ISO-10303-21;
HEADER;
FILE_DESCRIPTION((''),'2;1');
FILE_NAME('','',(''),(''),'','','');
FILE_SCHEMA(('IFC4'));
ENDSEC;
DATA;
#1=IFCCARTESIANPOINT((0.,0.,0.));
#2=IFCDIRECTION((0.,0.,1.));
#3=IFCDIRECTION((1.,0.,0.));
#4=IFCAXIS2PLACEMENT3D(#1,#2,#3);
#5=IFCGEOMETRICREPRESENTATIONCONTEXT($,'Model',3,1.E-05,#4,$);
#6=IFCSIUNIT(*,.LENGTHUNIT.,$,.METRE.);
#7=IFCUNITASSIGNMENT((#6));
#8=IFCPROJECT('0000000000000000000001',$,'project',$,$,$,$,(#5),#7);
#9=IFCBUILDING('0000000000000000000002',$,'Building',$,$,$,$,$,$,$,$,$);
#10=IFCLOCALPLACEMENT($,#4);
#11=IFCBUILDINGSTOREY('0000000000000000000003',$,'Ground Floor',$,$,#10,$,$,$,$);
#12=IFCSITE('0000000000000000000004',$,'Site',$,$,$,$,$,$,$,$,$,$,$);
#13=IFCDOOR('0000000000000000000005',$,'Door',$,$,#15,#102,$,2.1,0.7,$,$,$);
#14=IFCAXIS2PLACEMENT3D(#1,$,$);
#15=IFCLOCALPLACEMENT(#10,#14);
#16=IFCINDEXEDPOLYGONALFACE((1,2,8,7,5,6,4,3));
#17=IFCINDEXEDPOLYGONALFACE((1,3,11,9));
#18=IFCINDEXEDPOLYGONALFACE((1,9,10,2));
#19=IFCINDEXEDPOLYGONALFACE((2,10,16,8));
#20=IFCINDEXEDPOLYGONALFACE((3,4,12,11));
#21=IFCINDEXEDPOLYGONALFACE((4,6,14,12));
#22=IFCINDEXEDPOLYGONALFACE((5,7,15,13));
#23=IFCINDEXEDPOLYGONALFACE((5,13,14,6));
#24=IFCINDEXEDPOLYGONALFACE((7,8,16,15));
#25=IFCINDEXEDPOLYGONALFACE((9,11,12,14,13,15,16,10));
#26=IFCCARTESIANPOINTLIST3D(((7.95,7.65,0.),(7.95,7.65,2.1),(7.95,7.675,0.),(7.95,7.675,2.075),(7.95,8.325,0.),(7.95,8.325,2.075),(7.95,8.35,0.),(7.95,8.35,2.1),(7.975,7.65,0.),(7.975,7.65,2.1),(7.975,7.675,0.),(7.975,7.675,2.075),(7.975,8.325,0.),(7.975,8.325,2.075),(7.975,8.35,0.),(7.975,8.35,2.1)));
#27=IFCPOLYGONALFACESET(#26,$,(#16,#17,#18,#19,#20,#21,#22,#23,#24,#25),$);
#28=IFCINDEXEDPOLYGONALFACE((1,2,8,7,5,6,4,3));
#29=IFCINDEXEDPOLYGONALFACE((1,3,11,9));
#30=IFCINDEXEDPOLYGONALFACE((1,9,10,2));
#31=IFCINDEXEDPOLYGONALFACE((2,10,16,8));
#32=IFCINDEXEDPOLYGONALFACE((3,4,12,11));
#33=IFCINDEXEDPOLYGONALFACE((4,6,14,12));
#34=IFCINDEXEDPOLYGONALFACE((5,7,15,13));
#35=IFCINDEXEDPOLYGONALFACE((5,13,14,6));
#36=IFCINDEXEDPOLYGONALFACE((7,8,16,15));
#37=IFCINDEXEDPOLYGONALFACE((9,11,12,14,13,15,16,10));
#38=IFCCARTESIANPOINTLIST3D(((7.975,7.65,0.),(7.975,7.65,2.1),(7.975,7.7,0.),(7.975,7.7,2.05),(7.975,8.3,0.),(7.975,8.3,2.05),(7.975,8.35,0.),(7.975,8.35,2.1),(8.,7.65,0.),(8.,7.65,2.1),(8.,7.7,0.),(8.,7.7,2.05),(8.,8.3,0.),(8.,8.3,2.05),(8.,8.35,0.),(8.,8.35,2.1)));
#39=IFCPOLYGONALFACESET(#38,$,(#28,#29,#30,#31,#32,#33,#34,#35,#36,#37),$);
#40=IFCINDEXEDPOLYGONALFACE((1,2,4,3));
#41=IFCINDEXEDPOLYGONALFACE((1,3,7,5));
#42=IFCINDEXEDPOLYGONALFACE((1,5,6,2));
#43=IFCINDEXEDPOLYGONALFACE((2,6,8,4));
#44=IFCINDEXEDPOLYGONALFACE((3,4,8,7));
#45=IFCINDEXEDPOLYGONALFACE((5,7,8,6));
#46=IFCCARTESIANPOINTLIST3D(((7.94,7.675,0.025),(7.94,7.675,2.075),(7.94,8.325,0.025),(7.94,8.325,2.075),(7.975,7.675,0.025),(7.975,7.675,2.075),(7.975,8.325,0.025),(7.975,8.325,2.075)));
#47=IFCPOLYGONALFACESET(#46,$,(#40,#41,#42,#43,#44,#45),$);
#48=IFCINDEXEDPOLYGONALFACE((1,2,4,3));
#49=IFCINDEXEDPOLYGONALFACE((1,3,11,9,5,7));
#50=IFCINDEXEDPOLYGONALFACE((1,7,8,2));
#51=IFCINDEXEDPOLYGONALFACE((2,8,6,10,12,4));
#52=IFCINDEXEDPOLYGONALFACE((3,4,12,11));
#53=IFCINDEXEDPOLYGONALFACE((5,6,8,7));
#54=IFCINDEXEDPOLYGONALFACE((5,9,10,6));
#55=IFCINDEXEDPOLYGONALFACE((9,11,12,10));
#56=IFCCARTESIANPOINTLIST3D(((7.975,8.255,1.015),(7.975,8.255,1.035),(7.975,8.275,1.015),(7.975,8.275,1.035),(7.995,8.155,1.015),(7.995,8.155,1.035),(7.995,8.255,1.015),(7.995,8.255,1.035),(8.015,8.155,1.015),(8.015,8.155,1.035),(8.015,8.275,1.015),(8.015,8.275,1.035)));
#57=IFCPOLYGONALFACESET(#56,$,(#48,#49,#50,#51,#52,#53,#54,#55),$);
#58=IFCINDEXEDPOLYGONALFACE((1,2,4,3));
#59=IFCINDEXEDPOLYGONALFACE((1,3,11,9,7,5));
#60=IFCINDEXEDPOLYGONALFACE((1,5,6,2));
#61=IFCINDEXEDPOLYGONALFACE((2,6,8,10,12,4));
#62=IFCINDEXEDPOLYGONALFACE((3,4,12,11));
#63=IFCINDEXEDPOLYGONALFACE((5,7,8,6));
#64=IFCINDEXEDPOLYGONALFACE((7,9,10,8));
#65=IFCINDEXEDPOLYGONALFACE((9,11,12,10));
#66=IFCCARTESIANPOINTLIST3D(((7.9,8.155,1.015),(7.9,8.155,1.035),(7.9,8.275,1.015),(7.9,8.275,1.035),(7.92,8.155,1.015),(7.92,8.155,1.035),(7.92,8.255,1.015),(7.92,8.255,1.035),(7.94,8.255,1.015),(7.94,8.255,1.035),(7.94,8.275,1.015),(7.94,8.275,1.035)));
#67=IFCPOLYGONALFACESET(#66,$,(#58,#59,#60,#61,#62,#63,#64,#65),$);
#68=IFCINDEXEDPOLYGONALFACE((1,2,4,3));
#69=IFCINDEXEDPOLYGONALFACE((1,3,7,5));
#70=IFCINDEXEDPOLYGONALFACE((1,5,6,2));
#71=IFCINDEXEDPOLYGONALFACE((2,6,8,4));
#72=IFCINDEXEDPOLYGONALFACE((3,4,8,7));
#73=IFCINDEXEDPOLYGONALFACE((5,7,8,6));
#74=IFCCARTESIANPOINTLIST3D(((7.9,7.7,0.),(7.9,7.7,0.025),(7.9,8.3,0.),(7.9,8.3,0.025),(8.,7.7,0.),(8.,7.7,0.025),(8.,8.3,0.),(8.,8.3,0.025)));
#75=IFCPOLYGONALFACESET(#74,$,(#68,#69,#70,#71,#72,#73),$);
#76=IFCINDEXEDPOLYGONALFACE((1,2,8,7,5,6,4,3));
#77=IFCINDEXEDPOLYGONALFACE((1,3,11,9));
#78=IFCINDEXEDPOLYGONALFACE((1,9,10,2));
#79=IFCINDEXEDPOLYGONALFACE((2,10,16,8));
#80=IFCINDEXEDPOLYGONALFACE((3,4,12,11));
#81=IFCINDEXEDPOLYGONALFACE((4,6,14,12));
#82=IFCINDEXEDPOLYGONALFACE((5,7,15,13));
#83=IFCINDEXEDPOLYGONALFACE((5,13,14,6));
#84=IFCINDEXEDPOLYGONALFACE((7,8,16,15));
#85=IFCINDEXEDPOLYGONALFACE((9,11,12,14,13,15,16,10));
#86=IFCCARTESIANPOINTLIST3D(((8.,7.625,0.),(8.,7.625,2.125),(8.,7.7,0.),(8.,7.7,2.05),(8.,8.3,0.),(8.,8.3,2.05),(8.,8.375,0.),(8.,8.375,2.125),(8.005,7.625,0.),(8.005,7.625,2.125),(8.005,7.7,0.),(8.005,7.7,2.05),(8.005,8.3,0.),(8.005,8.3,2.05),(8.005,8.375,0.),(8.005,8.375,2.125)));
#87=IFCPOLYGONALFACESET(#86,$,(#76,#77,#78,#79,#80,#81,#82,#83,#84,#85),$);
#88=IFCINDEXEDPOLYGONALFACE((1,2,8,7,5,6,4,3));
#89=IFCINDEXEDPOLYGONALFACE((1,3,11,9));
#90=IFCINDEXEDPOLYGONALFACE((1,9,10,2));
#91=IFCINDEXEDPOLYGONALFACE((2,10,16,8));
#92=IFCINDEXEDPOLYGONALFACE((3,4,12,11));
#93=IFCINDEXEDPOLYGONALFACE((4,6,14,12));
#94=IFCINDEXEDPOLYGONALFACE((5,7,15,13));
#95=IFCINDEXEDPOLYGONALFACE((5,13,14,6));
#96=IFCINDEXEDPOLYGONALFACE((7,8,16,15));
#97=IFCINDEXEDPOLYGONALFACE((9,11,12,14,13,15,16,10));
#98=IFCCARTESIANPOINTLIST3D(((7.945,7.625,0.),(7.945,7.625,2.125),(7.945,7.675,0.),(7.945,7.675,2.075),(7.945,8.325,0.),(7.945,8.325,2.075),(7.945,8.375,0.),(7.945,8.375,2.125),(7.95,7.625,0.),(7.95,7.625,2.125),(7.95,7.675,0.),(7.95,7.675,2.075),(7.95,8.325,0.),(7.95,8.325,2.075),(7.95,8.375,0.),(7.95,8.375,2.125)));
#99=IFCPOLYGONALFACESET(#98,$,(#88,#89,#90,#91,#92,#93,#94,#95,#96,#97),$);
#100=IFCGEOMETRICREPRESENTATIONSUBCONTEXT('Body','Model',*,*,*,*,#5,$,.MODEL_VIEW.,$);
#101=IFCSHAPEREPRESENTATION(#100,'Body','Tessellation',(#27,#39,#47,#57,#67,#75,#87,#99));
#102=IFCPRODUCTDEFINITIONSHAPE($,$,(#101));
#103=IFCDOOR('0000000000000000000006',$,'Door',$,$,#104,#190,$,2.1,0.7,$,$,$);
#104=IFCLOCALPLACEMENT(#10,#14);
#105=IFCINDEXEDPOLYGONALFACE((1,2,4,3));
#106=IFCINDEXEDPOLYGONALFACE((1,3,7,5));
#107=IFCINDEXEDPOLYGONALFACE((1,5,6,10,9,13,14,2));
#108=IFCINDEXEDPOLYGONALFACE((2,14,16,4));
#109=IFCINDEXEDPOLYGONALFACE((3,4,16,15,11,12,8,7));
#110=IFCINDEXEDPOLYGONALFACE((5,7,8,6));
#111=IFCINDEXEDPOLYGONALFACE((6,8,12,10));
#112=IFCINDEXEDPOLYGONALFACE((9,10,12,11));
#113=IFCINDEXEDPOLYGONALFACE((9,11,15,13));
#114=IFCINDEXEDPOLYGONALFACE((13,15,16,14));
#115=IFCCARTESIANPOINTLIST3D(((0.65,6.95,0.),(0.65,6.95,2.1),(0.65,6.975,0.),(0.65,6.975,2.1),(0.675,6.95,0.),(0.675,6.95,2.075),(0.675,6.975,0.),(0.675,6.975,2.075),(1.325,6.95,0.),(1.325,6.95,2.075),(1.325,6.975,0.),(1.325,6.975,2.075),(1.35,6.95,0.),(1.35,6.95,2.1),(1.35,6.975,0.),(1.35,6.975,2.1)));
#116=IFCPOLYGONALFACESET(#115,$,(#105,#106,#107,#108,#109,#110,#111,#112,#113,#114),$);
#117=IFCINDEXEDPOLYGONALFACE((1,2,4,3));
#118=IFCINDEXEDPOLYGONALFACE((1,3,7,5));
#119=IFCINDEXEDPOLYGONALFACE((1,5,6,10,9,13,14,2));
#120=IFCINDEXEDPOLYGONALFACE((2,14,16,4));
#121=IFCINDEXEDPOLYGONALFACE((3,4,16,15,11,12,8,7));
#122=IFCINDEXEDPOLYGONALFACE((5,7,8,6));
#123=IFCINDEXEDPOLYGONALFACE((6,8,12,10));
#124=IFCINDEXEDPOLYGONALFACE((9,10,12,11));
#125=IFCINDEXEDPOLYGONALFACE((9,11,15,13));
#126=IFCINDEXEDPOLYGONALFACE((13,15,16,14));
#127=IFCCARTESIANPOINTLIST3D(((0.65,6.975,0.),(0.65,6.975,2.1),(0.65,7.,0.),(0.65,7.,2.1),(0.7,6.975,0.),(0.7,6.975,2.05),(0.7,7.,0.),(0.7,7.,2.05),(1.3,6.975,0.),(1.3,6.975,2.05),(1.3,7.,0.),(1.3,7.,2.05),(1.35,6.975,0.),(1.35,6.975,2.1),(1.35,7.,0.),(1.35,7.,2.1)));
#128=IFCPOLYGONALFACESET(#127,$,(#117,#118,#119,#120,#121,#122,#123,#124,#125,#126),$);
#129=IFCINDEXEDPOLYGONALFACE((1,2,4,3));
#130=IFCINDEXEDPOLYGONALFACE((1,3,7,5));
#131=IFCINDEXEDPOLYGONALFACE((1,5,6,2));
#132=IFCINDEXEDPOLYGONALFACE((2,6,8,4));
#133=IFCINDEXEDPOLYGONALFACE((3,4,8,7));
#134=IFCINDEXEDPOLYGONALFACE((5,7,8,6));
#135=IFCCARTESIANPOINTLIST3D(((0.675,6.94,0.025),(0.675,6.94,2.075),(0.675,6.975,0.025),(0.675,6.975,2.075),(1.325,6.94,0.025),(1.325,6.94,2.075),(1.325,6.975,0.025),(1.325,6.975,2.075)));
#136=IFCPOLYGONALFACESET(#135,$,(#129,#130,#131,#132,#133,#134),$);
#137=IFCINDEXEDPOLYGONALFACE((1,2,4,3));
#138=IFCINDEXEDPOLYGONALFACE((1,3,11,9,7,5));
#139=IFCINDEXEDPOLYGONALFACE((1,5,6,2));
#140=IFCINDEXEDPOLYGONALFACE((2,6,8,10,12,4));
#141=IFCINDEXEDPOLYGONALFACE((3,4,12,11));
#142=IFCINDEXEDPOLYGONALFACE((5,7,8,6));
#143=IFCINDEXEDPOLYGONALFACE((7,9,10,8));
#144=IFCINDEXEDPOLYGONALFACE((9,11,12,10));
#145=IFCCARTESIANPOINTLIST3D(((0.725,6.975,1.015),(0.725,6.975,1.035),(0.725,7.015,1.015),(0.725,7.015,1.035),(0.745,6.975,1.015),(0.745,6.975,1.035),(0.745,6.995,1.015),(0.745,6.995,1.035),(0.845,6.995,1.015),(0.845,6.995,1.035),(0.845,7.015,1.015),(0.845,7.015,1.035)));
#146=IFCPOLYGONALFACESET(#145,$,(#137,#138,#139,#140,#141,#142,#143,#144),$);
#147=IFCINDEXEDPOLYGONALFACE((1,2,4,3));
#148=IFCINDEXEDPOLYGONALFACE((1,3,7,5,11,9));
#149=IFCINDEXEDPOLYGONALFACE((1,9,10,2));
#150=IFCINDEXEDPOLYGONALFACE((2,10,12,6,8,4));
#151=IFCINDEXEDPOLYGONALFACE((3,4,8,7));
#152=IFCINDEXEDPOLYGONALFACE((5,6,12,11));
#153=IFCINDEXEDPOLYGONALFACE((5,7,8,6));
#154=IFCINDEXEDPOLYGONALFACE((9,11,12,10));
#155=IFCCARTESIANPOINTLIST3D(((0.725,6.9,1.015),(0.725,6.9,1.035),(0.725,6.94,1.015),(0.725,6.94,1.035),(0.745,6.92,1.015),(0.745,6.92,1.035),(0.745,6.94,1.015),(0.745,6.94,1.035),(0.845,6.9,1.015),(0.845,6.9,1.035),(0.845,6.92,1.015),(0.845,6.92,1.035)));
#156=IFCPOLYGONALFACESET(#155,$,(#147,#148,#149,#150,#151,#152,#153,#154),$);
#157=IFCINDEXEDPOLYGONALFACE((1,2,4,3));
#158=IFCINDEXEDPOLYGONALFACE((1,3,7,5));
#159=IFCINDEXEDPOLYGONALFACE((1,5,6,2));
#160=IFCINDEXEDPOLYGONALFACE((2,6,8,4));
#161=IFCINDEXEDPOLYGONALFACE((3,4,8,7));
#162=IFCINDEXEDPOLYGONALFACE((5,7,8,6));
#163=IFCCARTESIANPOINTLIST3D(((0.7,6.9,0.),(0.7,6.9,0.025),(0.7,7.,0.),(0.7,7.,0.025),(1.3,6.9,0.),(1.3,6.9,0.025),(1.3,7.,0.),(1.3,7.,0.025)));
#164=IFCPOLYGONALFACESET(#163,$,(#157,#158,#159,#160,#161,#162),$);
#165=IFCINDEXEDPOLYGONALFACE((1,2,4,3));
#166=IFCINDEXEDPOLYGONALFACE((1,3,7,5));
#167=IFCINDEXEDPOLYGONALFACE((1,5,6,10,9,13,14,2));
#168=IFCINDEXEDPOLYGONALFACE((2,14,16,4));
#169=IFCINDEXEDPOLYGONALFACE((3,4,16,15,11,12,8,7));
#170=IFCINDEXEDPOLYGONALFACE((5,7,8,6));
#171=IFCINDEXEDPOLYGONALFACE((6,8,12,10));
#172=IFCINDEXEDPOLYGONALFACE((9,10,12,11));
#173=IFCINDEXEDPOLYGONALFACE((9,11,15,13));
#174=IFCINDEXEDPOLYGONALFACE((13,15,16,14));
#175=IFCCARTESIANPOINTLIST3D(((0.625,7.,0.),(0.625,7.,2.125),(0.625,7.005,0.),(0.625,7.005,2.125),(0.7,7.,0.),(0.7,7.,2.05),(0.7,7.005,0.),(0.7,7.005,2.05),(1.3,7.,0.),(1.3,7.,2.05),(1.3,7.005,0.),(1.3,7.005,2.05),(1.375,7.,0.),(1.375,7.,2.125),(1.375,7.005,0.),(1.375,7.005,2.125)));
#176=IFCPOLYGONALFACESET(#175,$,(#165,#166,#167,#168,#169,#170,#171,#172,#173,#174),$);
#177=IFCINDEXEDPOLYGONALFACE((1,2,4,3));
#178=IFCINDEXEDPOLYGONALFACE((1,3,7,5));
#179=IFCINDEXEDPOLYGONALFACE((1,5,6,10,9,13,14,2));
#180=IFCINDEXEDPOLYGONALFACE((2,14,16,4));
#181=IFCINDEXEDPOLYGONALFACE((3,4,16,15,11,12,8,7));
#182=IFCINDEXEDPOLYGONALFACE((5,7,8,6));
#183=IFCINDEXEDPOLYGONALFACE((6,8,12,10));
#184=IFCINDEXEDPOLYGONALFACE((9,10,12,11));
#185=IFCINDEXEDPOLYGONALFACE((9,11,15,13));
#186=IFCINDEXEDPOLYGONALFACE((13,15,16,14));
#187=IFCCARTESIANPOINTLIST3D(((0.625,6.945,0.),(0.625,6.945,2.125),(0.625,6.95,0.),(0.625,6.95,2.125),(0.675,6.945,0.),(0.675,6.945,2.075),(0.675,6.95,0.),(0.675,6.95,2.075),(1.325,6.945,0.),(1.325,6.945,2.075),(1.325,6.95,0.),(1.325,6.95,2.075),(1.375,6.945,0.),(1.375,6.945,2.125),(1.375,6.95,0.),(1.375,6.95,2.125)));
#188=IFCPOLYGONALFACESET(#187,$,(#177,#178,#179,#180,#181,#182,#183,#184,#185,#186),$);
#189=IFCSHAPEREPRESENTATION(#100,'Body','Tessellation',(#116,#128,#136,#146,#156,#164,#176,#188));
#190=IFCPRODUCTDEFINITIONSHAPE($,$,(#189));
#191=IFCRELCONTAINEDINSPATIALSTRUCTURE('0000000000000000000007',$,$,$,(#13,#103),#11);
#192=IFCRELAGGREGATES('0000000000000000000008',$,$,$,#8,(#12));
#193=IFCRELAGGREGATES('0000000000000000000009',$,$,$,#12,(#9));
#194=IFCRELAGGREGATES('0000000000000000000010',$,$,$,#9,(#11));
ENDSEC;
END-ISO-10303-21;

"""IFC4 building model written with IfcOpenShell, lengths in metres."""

from ifc_helpers import new_model, si_unit, frame, origin_with_axes, place, context, subcontext, project, spatial, line, indexed_curve, outline, extrude, element, save


model = new_model("IFC4")

# Units and contexts
model_context = context("Model", 3, precision=1e-05, world=origin_with_axes())
body_context = subcontext(model_context, "Body", "Model", "MODEL_VIEW")
ifc_project = project(units=[si_unit("LENGTHUNIT", "METRE")], contexts=[model_context])

# Site, building, storey
site = spatial("IfcSite", under=ifc_project, Name="Site")
building = spatial("IfcBuilding", under=site, Name="Building")
storey_placement = place(None, origin_with_axes())
storey = spatial("IfcBuildingStorey", under=building, at=storey_placement, Name="Ground Floor")

# Doors
door_1_placement = place(storey_placement, frame((8.0, 7.65, 0.0), z_axis=(0.0, 0.0, 1.0), x_axis=(0.0, 1.0, 0.0)))
element("IfcDoor", 1, at=door_1_placement, inside=storey, Name="Door", OverallHeight=2.1, OverallWidth=0.7, context=body_context, shape_type="SweptSolid", body=[
    extrude(outline(indexed_curve([(0.0, 0.0), (0.0, 2.1), (0.7, 2.1), (0.7, 0.0), (0.675, 0.0), (0.675, 2.075), (0.025, 2.075), (0.025, 0.0)], segments=[line(1, 2, 3, 4, 5, 6, 7, 8, 1)])), frame((0.0, 0.025, 0.0), z_axis=(0.0, -1.0, 0.0), x_axis=(1.0, 0.0, 0.0)), (0.0, 0.0, -1.0), 0.025),
    extrude(outline(indexed_curve([(0.0, 0.0), (0.0, 2.1), (0.7, 2.1), (0.7, 0.0), (0.65, 0.0), (0.65, 2.05), (0.05, 2.05), (0.05, 0.0)], segments=[line(1, 2, 3, 4, 5, 6, 7, 8, 1)])), frame((0.0, 0.0, 0.0), z_axis=(0.0, -1.0, 0.0), x_axis=(1.0, 0.0, 0.0)), (0.0, 0.0, -1.0), 0.025),
    extrude(outline(indexed_curve([(0.0, 0.0), (0.65, 0.0), (0.65, 0.035), (0.0, 0.035)], segments=[line(1, 2, 3, 4, 1)])), frame((0.025, 0.025, 0.025), z_axis=(0.0, 0.0, 1.0), x_axis=(1.0, 0.0, 0.0)), (0.0, 0.0, 1.0), 2.05),
    extrude(outline(indexed_curve([(0.0, 0.0), (0.0, -0.04), (-0.12, -0.04), (-0.12, -0.02), (-0.02, -0.02), (-0.02, 0.0)], segments=[line(1, 2, 3, 4, 5, 6, 1)])), frame((0.625, 0.025, 1.015), z_axis=(0.0, 0.0, 1.0), x_axis=(1.0, 0.0, 0.0)), (0.0, 0.0, 1.0), 0.02),
    extrude(outline(indexed_curve([(0.0, 0.0), (0.0, 0.04), (-0.12, 0.04), (-0.12, 0.02), (-0.02, 0.02), (-0.02, 0.0)], segments=[line(1, 2, 3, 4, 5, 6, 1)])), frame((0.625, 0.06, 1.015), z_axis=(0.0, 0.0, 1.0), x_axis=(1.0, 0.0, 0.0)), (0.0, 0.0, 1.0), 0.02),
    extrude(outline(indexed_curve([(0.0, 0.0), (0.6, 0.0), (0.6, 0.1), (0.0, 0.1)], segments=[line(1, 2, 3, 4, 1)])), frame((0.05, 0.0, 0.0), z_axis=(0.0, 0.0, 1.0), x_axis=(1.0, 0.0, 0.0)), (0.0, 0.0, 1.0), 0.025),
    extrude(outline(indexed_curve([(0.0, 0.0), (0.0, 2.125), (0.75, 2.125), (0.75, 0.0), (0.675, 0.0), (0.675, 2.05), (0.075, 2.05), (0.075, 0.0)], segments=[line(1, 2, 3, 4, 5, 6, 7, 8, 1)])), frame((-0.025, -0.005, 0.0), z_axis=(0.0, -1.0, 0.0), x_axis=(1.0, 0.0, 0.0)), (0.0, 0.0, -1.0), 0.005),
    extrude(outline(indexed_curve([(0.0, 0.0), (0.0, 2.125), (0.75, 2.125), (0.75, 0.0), (0.7, 0.0), (0.7, 2.075), (0.05, 2.075), (0.05, 0.0)], segments=[line(1, 2, 3, 4, 5, 6, 7, 8, 1)])), frame((-0.025, 0.05, 0.0), z_axis=(0.0, -1.0, 0.0), x_axis=(1.0, 0.0, 0.0)), (0.0, 0.0, -1.0), 0.005),
])
door_2_placement = place(storey_placement, frame((1.35, 7.0, 0.0), z_axis=(0.0, 0.0, 1.0), x_axis=(-1.0, 0.0, 0.0)))
element("IfcDoor", 2, at=door_2_placement, inside=storey, Name="Door", OverallHeight=2.1, OverallWidth=0.7, context=body_context, shape_type="SweptSolid", body=[
    extrude(outline(indexed_curve([(0.0, 0.0), (0.0, 2.1), (0.7, 2.1), (0.7, 0.0), (0.675, 0.0), (0.675, 2.075), (0.025, 2.075), (0.025, 0.0)], segments=[line(1, 2, 3, 4, 5, 6, 7, 8, 1)])), frame((0.0, 0.025, 0.0), z_axis=(0.0, -1.0, 0.0), x_axis=(1.0, 0.0, 0.0)), (0.0, 0.0, -1.0), 0.025),
    extrude(outline(indexed_curve([(0.0, 0.0), (0.0, 2.1), (0.7, 2.1), (0.7, 0.0), (0.65, 0.0), (0.65, 2.05), (0.05, 2.05), (0.05, 0.0)], segments=[line(1, 2, 3, 4, 5, 6, 7, 8, 1)])), frame((0.0, 0.0, 0.0), z_axis=(0.0, -1.0, 0.0), x_axis=(1.0, 0.0, 0.0)), (0.0, 0.0, -1.0), 0.025),
    extrude(outline(indexed_curve([(0.0, 0.0), (0.65, 0.0), (0.65, 0.035), (0.0, 0.035)], segments=[line(1, 2, 3, 4, 1)])), frame((0.025, 0.025, 0.025), z_axis=(0.0, 0.0, 1.0), x_axis=(1.0, 0.0, 0.0)), (0.0, 0.0, 1.0), 2.05),
    extrude(outline(indexed_curve([(0.0, 0.0), (0.0, -0.04), (-0.12, -0.04), (-0.12, -0.02), (-0.02, -0.02), (-0.02, 0.0)], segments=[line(1, 2, 3, 4, 5, 6, 1)])), frame((0.625, 0.025, 1.015), z_axis=(0.0, 0.0, 1.0), x_axis=(1.0, 0.0, 0.0)), (0.0, 0.0, 1.0), 0.02),
    extrude(outline(indexed_curve([(0.0, 0.0), (0.0, 0.04), (-0.12, 0.04), (-0.12, 0.02), (-0.02, 0.02), (-0.02, 0.0)], segments=[line(1, 2, 3, 4, 5, 6, 1)])), frame((0.625, 0.06, 1.015), z_axis=(0.0, 0.0, 1.0), x_axis=(1.0, 0.0, 0.0)), (0.0, 0.0, 1.0), 0.02),
    extrude(outline(indexed_curve([(0.0, 0.0), (0.6, 0.0), (0.6, 0.1), (0.0, 0.1)], segments=[line(1, 2, 3, 4, 1)])), frame((0.05, 0.0, 0.0), z_axis=(0.0, 0.0, 1.0), x_axis=(1.0, 0.0, 0.0)), (0.0, 0.0, 1.0), 0.025),
    extrude(outline(indexed_curve([(0.0, 0.0), (0.0, 2.125), (0.75, 2.125), (0.75, 0.0), (0.675, 0.0), (0.675, 2.05), (0.075, 2.05), (0.075, 0.0)], segments=[line(1, 2, 3, 4, 5, 6, 7, 8, 1)])), frame((-0.025, -0.005, 0.0), z_axis=(0.0, -1.0, 0.0), x_axis=(1.0, 0.0, 0.0)), (0.0, 0.0, -1.0), 0.005),
    extrude(outline(indexed_curve([(0.0, 0.0), (0.0, 2.125), (0.75, 2.125), (0.75, 0.0), (0.7, 0.0), (0.7, 2.075), (0.05, 2.075), (0.05, 0.0)], segments=[line(1, 2, 3, 4, 5, 6, 7, 8, 1)])), frame((-0.025, 0.05, 0.0), z_axis=(0.0, -1.0, 0.0), x_axis=(1.0, 0.0, 0.0)), (0.0, 0.0, -1.0), 0.005),
])

save(model, "model.ifc")
